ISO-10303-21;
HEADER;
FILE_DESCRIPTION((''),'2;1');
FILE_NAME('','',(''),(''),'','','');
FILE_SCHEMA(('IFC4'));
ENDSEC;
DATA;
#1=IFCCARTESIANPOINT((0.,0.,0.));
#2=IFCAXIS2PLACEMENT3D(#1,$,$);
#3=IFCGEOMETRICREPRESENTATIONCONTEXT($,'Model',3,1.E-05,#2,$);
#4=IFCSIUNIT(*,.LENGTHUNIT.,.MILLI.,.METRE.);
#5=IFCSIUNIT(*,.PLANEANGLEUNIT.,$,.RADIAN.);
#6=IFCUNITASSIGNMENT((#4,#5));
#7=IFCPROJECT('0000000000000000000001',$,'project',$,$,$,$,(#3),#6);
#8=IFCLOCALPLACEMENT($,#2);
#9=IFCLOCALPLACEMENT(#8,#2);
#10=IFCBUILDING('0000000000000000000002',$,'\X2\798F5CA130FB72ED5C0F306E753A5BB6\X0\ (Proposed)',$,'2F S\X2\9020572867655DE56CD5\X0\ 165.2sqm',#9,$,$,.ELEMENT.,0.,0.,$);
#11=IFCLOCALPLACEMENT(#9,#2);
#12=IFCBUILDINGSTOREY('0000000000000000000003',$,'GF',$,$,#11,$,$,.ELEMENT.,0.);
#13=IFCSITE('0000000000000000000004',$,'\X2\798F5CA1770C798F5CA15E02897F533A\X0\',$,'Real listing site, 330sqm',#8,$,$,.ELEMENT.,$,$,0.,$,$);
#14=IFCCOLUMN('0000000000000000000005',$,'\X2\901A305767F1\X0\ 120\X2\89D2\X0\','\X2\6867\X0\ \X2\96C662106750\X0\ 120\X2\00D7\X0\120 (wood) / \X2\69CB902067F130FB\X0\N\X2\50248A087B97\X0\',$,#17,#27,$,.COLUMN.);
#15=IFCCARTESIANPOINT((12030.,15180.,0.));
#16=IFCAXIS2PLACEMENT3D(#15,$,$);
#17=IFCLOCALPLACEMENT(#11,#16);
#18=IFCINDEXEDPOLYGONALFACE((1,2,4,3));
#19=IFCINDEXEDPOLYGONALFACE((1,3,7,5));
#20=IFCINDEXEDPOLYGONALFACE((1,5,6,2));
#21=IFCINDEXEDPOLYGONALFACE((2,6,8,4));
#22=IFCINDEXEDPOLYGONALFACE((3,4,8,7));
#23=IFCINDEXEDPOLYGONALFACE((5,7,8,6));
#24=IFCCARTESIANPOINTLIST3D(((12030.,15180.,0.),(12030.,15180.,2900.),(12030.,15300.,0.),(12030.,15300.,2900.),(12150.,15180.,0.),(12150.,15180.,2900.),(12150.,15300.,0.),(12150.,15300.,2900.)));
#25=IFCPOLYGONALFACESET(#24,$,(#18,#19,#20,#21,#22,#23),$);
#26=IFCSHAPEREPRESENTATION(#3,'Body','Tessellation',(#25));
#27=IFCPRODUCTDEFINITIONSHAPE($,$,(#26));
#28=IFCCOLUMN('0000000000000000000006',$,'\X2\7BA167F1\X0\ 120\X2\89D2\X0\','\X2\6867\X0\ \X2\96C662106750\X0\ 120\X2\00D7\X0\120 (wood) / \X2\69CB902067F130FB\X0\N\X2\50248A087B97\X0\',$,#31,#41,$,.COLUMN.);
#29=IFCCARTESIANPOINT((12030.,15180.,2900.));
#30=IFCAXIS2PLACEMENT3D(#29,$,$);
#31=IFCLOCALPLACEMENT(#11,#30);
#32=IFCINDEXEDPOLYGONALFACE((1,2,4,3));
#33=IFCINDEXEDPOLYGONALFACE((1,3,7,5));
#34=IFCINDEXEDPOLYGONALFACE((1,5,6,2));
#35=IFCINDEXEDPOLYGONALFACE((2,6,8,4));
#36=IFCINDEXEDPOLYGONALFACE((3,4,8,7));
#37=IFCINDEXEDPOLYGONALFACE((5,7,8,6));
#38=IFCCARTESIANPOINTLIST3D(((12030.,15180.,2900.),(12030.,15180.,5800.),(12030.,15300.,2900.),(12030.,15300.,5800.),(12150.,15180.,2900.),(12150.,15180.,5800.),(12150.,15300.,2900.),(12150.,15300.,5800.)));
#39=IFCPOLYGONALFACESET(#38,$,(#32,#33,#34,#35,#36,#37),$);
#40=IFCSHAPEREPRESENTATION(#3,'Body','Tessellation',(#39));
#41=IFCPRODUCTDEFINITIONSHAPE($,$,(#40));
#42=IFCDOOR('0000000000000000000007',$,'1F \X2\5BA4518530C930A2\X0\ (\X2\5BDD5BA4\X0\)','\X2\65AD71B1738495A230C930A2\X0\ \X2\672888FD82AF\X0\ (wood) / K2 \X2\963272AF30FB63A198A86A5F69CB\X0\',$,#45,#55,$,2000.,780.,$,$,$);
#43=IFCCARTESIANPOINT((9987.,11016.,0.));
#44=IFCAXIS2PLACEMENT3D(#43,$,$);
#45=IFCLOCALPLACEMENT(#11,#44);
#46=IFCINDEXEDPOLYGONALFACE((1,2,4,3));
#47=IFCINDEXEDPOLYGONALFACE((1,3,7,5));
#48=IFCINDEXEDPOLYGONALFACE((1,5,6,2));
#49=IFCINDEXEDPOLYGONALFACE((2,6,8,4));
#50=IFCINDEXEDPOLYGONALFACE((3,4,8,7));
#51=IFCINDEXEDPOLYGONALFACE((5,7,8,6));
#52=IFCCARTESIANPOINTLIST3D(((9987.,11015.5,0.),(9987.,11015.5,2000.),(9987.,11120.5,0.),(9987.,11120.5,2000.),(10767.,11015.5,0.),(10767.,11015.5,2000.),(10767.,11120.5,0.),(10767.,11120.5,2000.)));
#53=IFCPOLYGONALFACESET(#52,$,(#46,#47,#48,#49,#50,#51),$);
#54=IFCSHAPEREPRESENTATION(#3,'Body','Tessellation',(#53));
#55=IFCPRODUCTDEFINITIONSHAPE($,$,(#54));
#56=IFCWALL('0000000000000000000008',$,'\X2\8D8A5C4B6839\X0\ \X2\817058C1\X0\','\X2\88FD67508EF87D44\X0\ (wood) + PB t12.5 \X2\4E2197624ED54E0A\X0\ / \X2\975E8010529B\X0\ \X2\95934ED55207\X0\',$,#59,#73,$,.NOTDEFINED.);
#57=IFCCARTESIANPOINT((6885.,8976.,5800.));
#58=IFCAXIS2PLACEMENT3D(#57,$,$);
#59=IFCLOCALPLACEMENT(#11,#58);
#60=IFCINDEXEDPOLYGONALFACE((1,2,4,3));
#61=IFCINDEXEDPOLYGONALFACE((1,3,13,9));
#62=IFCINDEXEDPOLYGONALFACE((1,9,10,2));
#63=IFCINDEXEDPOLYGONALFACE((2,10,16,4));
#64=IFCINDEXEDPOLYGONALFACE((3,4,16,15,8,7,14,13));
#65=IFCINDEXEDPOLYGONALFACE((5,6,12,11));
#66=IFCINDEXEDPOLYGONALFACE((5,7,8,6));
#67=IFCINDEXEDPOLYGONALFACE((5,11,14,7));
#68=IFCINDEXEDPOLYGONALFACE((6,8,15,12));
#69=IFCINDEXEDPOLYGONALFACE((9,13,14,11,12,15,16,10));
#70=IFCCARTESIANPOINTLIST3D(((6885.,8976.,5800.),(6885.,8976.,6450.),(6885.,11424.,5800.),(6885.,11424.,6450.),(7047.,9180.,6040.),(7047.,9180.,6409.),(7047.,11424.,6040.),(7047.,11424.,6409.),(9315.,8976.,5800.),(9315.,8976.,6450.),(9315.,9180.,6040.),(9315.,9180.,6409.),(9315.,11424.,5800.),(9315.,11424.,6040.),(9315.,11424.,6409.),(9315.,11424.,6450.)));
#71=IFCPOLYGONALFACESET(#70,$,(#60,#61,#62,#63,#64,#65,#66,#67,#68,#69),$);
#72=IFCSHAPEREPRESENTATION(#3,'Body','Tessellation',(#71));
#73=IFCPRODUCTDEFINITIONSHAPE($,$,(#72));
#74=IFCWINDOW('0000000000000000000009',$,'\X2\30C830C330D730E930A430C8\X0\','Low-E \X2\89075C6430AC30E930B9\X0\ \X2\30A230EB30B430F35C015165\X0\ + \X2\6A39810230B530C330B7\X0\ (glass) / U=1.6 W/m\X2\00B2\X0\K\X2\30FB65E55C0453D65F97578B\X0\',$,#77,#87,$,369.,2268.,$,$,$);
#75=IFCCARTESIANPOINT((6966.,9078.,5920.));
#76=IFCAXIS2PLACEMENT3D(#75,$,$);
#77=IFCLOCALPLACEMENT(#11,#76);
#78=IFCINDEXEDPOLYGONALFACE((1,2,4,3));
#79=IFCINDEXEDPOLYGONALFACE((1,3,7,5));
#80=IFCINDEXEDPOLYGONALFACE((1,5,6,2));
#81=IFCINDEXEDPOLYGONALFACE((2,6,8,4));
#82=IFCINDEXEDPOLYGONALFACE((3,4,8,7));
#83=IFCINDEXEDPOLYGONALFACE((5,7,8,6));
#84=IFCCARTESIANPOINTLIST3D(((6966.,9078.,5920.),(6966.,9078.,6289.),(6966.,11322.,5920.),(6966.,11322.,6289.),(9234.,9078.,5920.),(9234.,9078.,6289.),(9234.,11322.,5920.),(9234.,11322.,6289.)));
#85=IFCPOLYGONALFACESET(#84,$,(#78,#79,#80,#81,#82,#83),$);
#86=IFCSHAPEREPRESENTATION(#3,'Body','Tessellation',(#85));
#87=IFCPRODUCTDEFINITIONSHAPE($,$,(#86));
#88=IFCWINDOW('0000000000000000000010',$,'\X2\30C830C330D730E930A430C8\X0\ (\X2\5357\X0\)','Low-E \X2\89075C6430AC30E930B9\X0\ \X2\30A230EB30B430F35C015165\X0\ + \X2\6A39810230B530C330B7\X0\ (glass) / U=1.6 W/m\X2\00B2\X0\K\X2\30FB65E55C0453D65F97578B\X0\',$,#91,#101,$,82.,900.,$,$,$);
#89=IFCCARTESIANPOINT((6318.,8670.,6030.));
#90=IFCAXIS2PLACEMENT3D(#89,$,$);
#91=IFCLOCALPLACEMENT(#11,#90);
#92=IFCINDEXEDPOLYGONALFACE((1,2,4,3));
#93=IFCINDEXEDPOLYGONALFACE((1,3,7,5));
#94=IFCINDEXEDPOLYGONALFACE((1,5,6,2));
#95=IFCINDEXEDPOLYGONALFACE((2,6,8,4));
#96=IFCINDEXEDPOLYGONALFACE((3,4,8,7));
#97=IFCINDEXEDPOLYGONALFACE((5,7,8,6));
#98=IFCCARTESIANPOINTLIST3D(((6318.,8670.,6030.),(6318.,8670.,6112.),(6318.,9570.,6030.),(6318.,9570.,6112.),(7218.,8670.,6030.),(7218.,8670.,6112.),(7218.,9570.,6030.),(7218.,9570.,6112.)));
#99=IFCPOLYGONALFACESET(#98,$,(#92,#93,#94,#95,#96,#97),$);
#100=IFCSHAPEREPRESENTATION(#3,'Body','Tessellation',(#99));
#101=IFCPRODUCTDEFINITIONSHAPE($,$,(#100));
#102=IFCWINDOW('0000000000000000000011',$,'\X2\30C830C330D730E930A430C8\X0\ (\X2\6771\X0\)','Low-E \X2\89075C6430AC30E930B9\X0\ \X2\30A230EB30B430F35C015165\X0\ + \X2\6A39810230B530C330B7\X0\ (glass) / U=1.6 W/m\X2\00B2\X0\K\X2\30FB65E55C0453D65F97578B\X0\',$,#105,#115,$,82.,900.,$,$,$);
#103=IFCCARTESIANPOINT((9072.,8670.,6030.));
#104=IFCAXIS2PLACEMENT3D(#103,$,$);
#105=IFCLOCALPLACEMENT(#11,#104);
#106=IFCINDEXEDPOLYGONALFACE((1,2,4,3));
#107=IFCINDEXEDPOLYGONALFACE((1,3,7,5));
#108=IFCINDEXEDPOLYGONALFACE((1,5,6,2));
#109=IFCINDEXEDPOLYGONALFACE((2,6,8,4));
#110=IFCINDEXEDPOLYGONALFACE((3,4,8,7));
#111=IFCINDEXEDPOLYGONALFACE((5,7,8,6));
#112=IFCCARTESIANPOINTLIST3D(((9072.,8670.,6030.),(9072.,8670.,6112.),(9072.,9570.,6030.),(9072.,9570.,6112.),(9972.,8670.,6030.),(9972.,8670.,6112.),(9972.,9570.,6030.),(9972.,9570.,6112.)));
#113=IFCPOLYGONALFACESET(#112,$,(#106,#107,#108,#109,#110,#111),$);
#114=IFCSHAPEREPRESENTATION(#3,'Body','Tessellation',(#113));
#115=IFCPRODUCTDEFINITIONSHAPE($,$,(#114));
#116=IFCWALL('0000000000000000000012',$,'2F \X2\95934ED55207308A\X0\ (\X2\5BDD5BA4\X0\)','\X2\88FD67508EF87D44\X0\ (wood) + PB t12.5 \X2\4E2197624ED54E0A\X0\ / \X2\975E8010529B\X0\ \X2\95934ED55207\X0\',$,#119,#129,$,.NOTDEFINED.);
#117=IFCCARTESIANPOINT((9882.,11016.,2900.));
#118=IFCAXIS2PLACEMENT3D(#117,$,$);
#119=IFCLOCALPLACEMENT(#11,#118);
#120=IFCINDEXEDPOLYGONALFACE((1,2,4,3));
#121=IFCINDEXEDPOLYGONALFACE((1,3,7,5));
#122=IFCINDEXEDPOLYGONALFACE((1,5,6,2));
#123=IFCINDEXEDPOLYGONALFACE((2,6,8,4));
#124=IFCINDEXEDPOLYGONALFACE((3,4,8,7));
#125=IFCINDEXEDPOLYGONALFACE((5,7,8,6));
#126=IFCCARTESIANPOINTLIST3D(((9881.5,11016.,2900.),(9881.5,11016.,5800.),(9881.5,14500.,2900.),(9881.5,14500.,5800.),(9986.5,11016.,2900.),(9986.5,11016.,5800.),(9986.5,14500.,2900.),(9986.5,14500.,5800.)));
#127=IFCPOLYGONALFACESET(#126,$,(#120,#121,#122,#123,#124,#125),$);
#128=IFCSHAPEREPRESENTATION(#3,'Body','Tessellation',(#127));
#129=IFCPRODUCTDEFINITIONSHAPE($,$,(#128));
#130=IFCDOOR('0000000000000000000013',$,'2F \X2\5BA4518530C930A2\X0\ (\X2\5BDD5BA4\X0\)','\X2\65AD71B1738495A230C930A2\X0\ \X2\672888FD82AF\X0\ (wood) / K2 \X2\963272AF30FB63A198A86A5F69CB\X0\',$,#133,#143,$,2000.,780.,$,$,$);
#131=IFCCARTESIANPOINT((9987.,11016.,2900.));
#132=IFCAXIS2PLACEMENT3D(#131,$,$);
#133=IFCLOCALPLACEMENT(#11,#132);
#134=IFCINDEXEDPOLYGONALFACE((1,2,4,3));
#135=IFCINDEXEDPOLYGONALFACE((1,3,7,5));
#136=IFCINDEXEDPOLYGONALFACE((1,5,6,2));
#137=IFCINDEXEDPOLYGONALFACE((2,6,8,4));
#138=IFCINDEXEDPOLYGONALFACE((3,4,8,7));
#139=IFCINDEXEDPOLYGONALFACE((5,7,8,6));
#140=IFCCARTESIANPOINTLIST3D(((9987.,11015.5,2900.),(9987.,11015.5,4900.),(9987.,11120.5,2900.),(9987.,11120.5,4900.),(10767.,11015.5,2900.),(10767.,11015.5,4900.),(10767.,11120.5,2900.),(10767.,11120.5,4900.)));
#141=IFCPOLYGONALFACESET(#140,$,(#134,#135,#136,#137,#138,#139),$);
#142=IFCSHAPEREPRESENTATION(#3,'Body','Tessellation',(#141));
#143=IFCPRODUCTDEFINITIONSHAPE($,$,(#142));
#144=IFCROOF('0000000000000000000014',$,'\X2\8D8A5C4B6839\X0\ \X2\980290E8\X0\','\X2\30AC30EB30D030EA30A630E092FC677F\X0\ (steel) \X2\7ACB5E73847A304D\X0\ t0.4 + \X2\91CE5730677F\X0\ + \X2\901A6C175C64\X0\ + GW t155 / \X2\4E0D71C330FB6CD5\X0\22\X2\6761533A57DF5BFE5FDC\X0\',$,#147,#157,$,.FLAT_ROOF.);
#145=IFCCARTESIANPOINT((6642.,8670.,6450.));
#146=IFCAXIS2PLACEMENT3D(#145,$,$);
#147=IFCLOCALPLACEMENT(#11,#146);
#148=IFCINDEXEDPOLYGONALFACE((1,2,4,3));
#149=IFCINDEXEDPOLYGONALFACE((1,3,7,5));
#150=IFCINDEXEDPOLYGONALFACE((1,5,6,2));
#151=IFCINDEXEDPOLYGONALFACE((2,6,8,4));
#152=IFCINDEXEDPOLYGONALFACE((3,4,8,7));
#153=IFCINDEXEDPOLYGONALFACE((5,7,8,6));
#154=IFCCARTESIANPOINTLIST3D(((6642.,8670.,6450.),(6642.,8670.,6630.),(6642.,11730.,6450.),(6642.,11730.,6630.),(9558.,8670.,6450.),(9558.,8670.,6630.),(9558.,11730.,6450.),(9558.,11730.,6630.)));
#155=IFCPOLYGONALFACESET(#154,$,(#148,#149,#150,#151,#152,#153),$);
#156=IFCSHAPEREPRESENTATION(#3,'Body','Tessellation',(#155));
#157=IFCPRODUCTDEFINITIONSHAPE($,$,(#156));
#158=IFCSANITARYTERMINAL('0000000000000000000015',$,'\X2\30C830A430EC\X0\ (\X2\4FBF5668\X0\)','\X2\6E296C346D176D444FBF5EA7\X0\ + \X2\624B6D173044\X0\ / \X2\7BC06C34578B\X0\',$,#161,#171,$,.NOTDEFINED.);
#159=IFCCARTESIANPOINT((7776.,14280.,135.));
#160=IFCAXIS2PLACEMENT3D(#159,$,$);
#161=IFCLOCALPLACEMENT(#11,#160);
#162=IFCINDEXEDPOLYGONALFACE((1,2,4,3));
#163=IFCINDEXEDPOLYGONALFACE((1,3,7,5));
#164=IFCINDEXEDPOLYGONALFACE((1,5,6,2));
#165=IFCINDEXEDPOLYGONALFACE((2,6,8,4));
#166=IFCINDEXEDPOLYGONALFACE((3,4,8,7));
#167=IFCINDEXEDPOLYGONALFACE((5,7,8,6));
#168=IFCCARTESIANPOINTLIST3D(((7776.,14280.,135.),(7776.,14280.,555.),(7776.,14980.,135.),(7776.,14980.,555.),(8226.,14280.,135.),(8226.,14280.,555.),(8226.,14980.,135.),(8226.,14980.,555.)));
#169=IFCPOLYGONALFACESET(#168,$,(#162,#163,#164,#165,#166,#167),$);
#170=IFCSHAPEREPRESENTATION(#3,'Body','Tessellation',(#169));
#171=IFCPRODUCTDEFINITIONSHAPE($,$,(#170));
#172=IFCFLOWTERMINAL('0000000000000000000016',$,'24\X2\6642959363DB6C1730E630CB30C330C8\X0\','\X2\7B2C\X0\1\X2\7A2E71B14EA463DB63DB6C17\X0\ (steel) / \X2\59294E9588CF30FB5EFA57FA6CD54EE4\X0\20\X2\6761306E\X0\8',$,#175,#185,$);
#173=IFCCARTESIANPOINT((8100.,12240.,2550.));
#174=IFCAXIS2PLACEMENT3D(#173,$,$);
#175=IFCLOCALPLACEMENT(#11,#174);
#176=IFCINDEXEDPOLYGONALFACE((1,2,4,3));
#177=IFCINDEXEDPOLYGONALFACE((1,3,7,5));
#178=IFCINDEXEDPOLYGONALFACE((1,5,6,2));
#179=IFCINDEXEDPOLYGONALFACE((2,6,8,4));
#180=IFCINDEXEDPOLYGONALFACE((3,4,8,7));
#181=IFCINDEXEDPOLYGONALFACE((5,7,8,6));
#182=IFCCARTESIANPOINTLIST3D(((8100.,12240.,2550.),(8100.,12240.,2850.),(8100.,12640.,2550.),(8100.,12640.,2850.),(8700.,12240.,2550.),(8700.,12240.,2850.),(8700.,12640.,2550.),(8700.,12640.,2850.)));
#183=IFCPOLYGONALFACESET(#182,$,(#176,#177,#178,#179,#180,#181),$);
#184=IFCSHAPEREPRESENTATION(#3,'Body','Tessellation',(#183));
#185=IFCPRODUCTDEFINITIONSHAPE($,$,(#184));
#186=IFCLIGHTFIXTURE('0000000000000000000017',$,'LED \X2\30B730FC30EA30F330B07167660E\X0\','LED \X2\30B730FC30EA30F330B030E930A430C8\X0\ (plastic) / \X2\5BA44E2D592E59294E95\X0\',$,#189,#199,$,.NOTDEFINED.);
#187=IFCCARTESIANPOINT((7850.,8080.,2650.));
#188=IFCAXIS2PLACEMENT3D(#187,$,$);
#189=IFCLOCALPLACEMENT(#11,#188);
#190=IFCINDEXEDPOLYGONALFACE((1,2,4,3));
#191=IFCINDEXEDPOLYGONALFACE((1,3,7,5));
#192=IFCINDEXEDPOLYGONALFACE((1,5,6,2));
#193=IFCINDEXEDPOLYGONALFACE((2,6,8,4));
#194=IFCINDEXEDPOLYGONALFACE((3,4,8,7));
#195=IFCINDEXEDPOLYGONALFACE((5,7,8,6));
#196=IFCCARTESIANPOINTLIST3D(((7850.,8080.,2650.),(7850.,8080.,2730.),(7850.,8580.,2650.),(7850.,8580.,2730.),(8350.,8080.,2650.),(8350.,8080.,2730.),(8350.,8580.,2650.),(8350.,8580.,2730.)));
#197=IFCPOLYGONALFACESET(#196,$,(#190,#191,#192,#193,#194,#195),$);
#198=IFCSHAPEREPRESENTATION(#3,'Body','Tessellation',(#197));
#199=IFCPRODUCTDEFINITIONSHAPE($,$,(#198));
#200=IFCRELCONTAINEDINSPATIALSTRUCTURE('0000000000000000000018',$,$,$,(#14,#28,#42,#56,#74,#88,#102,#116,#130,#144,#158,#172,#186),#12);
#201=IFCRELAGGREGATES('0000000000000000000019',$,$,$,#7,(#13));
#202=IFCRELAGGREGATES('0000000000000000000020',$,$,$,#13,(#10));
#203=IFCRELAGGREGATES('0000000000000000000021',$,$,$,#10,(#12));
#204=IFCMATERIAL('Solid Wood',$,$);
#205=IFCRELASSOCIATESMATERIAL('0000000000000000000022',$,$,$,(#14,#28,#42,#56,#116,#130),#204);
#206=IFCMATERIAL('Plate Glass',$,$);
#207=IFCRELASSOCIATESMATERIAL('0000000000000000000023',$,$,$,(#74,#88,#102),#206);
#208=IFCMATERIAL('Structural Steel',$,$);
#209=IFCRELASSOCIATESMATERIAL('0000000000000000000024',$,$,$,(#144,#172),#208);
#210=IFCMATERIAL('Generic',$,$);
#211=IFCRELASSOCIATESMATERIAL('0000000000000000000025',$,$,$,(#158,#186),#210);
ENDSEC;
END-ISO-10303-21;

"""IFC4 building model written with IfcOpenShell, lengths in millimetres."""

from ifc_helpers import new_model, si_unit, frame, frame_2d, origin, place, context, project, spatial, rectangle, extrude, material, element, fill, save


model = new_model("IFC4")

# Units and contexts
model_context = context("Model", 3, precision=1e-05, world=origin())
ifc_project = project(units=[si_unit("LENGTHUNIT", "METRE", prefix="MILLI"), si_unit("PLANEANGLEUNIT", "RADIAN")], contexts=[model_context])

# Site, building, storey
site_placement = place(None, origin())
site = spatial("IfcSite", under=ifc_project, at=site_placement, Name="福岡県福岡市西区", ObjectType="Real listing site, 330sqm", CompositionType="ELEMENT", RefElevation=0.0)
building_placement = place(site_placement, origin())
building = spatial("IfcBuilding", under=site, at=building_placement, Name="福岡・狭小の町家 (Proposed)", ObjectType="2F S造在来工法 165.2sqm", CompositionType="ELEMENT", ElevationOfRefHeight=0.0, ElevationOfTerrain=0.0)
storey_placement = place(building_placement, origin())
storey = spatial("IfcBuildingStorey", under=building, at=storey_placement, Name="GF", CompositionType="ELEMENT", Elevation=0.0)

# Columns
ifc_material_1 = material(Name="Solid Wood")
column_1_placement = place(storey_placement, frame((12030.0, 15180.0, 0.0)))
element("IfcColumn", 1, at=column_1_placement, inside=storey, material=ifc_material_1, Name="通し柱 120角", Description="桧 集成材 120×120 (wood) / 構造柱・N値計算", PredefinedType="COLUMN", context=model_context, shape_type="SweptSolid", body=[
    extrude(rectangle(XDim=120.0, YDim=120.0, at=frame_2d((60.0, 60.0))), frame((12030.0, 15180.0, 0.0)), (0.0, 0.0, 1.0), 2900.0),
])
column_2_placement = place(storey_placement, frame((12030.0, 15180.0, 2900.0)))
element("IfcColumn", 2, at=column_2_placement, inside=storey, material=ifc_material_1, Name="管柱 120角", Description="桧 集成材 120×120 (wood) / 構造柱・N値計算", PredefinedType="COLUMN", context=model_context, shape_type="SweptSolid", body=[
    extrude(rectangle(XDim=120.0, YDim=120.0, at=frame_2d((60.0, 60.0))), frame((12030.0, 15180.0, 2900.0)), (0.0, 0.0, 1.0), 2900.0),
])

# Door
door_1_placement = place(storey_placement, frame((9987.0, 11016.0, 0.0)))
element("IfcDoor", 3, at=door_1_placement, inside=storey, material=ifc_material_1, Name="1F 室内ドア (寝室)", Description="断熱玄関ドア 木製芯 (wood) / K2 防犯・採風機構", OverallHeight=2000.0, OverallWidth=780.0, context=model_context, shape_type="SweptSolid", body=[
    extrude(rectangle(XDim=780.0, YDim=105.0, at=frame_2d((390.0, 52.0))), frame((9987.0, 11016.0, 0.0)), (0.0, 0.0, 1.0), 2000.0),
])

# Wall, openings, windows
wall_1_placement = place(storey_placement, frame((6885.0, 8976.0, 5800.0)))
wall_1 = element("IfcWall", 4, at=wall_1_placement, inside=storey, material=ifc_material_1, Name="越屋根 腰壁", Description="製材軸組 (wood) + PB t12.5 両面仕上 / 非耐力 間仕切", PredefinedType="NOTDEFINED", context=model_context, shape_type="SweptSolid", body=[
    extrude(rectangle(XDim=2430.0, YDim=2448.0, at=frame_2d((1215.0, 1224.0))), frame((6885.0, 8976.0, 5800.0)), (0.0, 0.0, 1.0), 650.0),
])
opening_1_placement = place(storey_placement, frame((6966.0, 9078.0, 5920.0)))
opening_1 = element("IfcOpeningElement", 5, at=opening_1_placement, cuts=wall_1, PredefinedType="NOTDEFINED", context=model_context, shape_type="SweptSolid", body=[
    extrude(rectangle(XDim=2268.0, YDim=2244.0, at=frame_2d((1134.0, 1122.0))), frame((6966.0, 9078.0, 5920.0)), (0.0, 0.0, 1.0), 369.0),
])
opening_2_placement = place(storey_placement, frame((6318.0, 8670.0, 6030.0)))
opening_2 = element("IfcOpeningElement", 6, at=opening_2_placement, cuts=wall_1, PredefinedType="NOTDEFINED", context=model_context, shape_type="SweptSolid", body=[
    extrude(rectangle(XDim=900.0, YDim=900.0, at=frame_2d((450.0, 450.0))), frame((6318.0, 8670.0, 6030.0)), (0.0, 0.0, 1.0), 82.0),
])
opening_3_placement = place(storey_placement, frame((9072.0, 8670.0, 6030.0)))
opening_3 = element("IfcOpeningElement", 7, at=opening_3_placement, cuts=wall_1, PredefinedType="NOTDEFINED", context=model_context, shape_type="SweptSolid", body=[
    extrude(rectangle(XDim=900.0, YDim=900.0, at=frame_2d((450.0, 450.0))), frame((9072.0, 8670.0, 6030.0)), (0.0, 0.0, 1.0), 82.0),
])
ifc_material_2 = material(Name="Plate Glass")
window_1_placement = place(storey_placement, frame((6966.0, 9078.0, 5920.0)))
window_1 = element("IfcWindow", 8, at=window_1_placement, inside=storey, material=ifc_material_2, Name="トップライト", Description="Low-E 複層ガラス アルゴン封入 + 樹脂サッシ (glass) / U=1.6 W/m²K・日射取得型", OverallHeight=369.0, OverallWidth=2268.0, context=model_context, shape_type="SweptSolid", body=[
    extrude(rectangle(XDim=2268.0, YDim=2244.0, at=frame_2d((1134.0, 1122.0))), frame((6966.0, 9078.0, 5920.0)), (0.0, 0.0, 1.0), 369.0),
])
fill(opening_1, window_1)
window_2_placement = place(storey_placement, frame((6318.0, 8670.0, 6030.0)))
window_2 = element("IfcWindow", 9, at=window_2_placement, inside=storey, material=ifc_material_2, Name="トップライト (南)", Description="Low-E 複層ガラス アルゴン封入 + 樹脂サッシ (glass) / U=1.6 W/m²K・日射取得型", OverallHeight=82.0, OverallWidth=900.0, context=model_context, shape_type="SweptSolid", body=[
    extrude(rectangle(XDim=900.0, YDim=900.0, at=frame_2d((450.0, 450.0))), frame((6318.0, 8670.0, 6030.0)), (0.0, 0.0, 1.0), 82.0),
])
fill(opening_2, window_2)
window_3_placement = place(storey_placement, frame((9072.0, 8670.0, 6030.0)))
window_3 = element("IfcWindow", 10, at=window_3_placement, inside=storey, material=ifc_material_2, Name="トップライト (東)", Description="Low-E 複層ガラス アルゴン封入 + 樹脂サッシ (glass) / U=1.6 W/m²K・日射取得型", OverallHeight=82.0, OverallWidth=900.0, context=model_context, shape_type="SweptSolid", body=[
    extrude(rectangle(XDim=900.0, YDim=900.0, at=frame_2d((450.0, 450.0))), frame((9072.0, 8670.0, 6030.0)), (0.0, 0.0, 1.0), 82.0),
])
fill(opening_3, window_3)

# Wall
wall_2_placement = place(storey_placement, frame((9882.0, 11016.0, 2900.0)))
element("IfcWall", 11, at=wall_2_placement, inside=storey, material=ifc_material_1, Name="2F 間仕切り (寝室)", Description="製材軸組 (wood) + PB t12.5 両面仕上 / 非耐力 間仕切", PredefinedType="NOTDEFINED", context=model_context, shape_type="SweptSolid", body=[
    extrude(rectangle(XDim=105.0, YDim=3484.0, at=frame_2d((52.0, 1742.0))), frame((9882.0, 11016.0, 2900.0)), (0.0, 0.0, 1.0), 2900.0),
])

# Door
door_2_placement = place(storey_placement, frame((9987.0, 11016.0, 2900.0)))
element("IfcDoor", 12, at=door_2_placement, inside=storey, material=ifc_material_1, Name="2F 室内ドア (寝室)", Description="断熱玄関ドア 木製芯 (wood) / K2 防犯・採風機構", OverallHeight=2000.0, OverallWidth=780.0, context=model_context, shape_type="SweptSolid", body=[
    extrude(rectangle(XDim=780.0, YDim=105.0, at=frame_2d((390.0, 52.0))), frame((9987.0, 11016.0, 2900.0)), (0.0, 0.0, 1.0), 2000.0),
])

# Roof
ifc_material_3 = material(Name="Structural Steel")
roof_placement = place(storey_placement, frame((6642.0, 8670.0, 6450.0)))
element("IfcRoof", 13, at=roof_placement, inside=storey, material=ifc_material_3, Name="越屋根 頂部", Description="ガルバリウム鋼板 (steel) 立平葺き t0.4 + 野地板 + 通気層 + GW t155 / 不燃・法22条区域対応", PredefinedType="FLAT_ROOF", context=model_context, shape_type="SweptSolid", body=[
    extrude(rectangle(XDim=2916.0, YDim=3060.0, at=frame_2d((1458.0, 1530.0))), frame((6642.0, 8670.0, 6450.0)), (0.0, 0.0, 1.0), 180.0),
])

# Sanitary terminal
ifc_material_4 = material(Name="Generic")
sanitary_terminal_placement = place(storey_placement, frame((7776.0, 14280.0, 135.0)))
element("IfcSanitaryTerminal", 14, at=sanitary_terminal_placement, inside=storey, material=ifc_material_4, Name="トイレ (便器)", Description="温水洗浄便座 + 手洗い / 節水型", PredefinedType="NOTDEFINED", context=model_context, shape_type="SweptSolid", body=[
    extrude(rectangle(XDim=450.0, YDim=700.0, at=frame_2d((225.0, 350.0))), frame((7776.0, 14280.0, 135.0)), (0.0, 0.0, 1.0), 420.0),
])

# Flow terminal
flow_terminal_placement = place(storey_placement, frame((8100.0, 12240.0, 2550.0)))
element("IfcFlowTerminal", 15, at=flow_terminal_placement, inside=storey, material=ifc_material_3, Name="24時間換気ユニット", Description="第1種熱交換換気 (steel) / 天井裏・建基法令20条の8", context=model_context, shape_type="SweptSolid", body=[
    extrude(rectangle(XDim=600.0, YDim=400.0, at=frame_2d((300.0, 200.0))), frame((8100.0, 12240.0, 2550.0)), (0.0, 0.0, 1.0), 300.0),
])

# Light fixture
light_fixture_1_placement = place(storey_placement, frame((7850.0, 8080.0, 2650.0)))
element("IfcLightFixture", 16, at=light_fixture_1_placement, inside=storey, material=ifc_material_4, Name="LED シーリング照明", Description="LED シーリングライト (plastic) / 室中央天井", PredefinedType="NOTDEFINED", context=model_context, shape_type="SweptSolid", body=[
    extrude(rectangle(XDim=500.0, YDim=500.0, at=frame_2d((250.0, 250.0))), frame((7850.0, 8080.0, 2650.0)), (0.0, 0.0, 1.0), 80.0),
])

save(model, "model.ifc")
